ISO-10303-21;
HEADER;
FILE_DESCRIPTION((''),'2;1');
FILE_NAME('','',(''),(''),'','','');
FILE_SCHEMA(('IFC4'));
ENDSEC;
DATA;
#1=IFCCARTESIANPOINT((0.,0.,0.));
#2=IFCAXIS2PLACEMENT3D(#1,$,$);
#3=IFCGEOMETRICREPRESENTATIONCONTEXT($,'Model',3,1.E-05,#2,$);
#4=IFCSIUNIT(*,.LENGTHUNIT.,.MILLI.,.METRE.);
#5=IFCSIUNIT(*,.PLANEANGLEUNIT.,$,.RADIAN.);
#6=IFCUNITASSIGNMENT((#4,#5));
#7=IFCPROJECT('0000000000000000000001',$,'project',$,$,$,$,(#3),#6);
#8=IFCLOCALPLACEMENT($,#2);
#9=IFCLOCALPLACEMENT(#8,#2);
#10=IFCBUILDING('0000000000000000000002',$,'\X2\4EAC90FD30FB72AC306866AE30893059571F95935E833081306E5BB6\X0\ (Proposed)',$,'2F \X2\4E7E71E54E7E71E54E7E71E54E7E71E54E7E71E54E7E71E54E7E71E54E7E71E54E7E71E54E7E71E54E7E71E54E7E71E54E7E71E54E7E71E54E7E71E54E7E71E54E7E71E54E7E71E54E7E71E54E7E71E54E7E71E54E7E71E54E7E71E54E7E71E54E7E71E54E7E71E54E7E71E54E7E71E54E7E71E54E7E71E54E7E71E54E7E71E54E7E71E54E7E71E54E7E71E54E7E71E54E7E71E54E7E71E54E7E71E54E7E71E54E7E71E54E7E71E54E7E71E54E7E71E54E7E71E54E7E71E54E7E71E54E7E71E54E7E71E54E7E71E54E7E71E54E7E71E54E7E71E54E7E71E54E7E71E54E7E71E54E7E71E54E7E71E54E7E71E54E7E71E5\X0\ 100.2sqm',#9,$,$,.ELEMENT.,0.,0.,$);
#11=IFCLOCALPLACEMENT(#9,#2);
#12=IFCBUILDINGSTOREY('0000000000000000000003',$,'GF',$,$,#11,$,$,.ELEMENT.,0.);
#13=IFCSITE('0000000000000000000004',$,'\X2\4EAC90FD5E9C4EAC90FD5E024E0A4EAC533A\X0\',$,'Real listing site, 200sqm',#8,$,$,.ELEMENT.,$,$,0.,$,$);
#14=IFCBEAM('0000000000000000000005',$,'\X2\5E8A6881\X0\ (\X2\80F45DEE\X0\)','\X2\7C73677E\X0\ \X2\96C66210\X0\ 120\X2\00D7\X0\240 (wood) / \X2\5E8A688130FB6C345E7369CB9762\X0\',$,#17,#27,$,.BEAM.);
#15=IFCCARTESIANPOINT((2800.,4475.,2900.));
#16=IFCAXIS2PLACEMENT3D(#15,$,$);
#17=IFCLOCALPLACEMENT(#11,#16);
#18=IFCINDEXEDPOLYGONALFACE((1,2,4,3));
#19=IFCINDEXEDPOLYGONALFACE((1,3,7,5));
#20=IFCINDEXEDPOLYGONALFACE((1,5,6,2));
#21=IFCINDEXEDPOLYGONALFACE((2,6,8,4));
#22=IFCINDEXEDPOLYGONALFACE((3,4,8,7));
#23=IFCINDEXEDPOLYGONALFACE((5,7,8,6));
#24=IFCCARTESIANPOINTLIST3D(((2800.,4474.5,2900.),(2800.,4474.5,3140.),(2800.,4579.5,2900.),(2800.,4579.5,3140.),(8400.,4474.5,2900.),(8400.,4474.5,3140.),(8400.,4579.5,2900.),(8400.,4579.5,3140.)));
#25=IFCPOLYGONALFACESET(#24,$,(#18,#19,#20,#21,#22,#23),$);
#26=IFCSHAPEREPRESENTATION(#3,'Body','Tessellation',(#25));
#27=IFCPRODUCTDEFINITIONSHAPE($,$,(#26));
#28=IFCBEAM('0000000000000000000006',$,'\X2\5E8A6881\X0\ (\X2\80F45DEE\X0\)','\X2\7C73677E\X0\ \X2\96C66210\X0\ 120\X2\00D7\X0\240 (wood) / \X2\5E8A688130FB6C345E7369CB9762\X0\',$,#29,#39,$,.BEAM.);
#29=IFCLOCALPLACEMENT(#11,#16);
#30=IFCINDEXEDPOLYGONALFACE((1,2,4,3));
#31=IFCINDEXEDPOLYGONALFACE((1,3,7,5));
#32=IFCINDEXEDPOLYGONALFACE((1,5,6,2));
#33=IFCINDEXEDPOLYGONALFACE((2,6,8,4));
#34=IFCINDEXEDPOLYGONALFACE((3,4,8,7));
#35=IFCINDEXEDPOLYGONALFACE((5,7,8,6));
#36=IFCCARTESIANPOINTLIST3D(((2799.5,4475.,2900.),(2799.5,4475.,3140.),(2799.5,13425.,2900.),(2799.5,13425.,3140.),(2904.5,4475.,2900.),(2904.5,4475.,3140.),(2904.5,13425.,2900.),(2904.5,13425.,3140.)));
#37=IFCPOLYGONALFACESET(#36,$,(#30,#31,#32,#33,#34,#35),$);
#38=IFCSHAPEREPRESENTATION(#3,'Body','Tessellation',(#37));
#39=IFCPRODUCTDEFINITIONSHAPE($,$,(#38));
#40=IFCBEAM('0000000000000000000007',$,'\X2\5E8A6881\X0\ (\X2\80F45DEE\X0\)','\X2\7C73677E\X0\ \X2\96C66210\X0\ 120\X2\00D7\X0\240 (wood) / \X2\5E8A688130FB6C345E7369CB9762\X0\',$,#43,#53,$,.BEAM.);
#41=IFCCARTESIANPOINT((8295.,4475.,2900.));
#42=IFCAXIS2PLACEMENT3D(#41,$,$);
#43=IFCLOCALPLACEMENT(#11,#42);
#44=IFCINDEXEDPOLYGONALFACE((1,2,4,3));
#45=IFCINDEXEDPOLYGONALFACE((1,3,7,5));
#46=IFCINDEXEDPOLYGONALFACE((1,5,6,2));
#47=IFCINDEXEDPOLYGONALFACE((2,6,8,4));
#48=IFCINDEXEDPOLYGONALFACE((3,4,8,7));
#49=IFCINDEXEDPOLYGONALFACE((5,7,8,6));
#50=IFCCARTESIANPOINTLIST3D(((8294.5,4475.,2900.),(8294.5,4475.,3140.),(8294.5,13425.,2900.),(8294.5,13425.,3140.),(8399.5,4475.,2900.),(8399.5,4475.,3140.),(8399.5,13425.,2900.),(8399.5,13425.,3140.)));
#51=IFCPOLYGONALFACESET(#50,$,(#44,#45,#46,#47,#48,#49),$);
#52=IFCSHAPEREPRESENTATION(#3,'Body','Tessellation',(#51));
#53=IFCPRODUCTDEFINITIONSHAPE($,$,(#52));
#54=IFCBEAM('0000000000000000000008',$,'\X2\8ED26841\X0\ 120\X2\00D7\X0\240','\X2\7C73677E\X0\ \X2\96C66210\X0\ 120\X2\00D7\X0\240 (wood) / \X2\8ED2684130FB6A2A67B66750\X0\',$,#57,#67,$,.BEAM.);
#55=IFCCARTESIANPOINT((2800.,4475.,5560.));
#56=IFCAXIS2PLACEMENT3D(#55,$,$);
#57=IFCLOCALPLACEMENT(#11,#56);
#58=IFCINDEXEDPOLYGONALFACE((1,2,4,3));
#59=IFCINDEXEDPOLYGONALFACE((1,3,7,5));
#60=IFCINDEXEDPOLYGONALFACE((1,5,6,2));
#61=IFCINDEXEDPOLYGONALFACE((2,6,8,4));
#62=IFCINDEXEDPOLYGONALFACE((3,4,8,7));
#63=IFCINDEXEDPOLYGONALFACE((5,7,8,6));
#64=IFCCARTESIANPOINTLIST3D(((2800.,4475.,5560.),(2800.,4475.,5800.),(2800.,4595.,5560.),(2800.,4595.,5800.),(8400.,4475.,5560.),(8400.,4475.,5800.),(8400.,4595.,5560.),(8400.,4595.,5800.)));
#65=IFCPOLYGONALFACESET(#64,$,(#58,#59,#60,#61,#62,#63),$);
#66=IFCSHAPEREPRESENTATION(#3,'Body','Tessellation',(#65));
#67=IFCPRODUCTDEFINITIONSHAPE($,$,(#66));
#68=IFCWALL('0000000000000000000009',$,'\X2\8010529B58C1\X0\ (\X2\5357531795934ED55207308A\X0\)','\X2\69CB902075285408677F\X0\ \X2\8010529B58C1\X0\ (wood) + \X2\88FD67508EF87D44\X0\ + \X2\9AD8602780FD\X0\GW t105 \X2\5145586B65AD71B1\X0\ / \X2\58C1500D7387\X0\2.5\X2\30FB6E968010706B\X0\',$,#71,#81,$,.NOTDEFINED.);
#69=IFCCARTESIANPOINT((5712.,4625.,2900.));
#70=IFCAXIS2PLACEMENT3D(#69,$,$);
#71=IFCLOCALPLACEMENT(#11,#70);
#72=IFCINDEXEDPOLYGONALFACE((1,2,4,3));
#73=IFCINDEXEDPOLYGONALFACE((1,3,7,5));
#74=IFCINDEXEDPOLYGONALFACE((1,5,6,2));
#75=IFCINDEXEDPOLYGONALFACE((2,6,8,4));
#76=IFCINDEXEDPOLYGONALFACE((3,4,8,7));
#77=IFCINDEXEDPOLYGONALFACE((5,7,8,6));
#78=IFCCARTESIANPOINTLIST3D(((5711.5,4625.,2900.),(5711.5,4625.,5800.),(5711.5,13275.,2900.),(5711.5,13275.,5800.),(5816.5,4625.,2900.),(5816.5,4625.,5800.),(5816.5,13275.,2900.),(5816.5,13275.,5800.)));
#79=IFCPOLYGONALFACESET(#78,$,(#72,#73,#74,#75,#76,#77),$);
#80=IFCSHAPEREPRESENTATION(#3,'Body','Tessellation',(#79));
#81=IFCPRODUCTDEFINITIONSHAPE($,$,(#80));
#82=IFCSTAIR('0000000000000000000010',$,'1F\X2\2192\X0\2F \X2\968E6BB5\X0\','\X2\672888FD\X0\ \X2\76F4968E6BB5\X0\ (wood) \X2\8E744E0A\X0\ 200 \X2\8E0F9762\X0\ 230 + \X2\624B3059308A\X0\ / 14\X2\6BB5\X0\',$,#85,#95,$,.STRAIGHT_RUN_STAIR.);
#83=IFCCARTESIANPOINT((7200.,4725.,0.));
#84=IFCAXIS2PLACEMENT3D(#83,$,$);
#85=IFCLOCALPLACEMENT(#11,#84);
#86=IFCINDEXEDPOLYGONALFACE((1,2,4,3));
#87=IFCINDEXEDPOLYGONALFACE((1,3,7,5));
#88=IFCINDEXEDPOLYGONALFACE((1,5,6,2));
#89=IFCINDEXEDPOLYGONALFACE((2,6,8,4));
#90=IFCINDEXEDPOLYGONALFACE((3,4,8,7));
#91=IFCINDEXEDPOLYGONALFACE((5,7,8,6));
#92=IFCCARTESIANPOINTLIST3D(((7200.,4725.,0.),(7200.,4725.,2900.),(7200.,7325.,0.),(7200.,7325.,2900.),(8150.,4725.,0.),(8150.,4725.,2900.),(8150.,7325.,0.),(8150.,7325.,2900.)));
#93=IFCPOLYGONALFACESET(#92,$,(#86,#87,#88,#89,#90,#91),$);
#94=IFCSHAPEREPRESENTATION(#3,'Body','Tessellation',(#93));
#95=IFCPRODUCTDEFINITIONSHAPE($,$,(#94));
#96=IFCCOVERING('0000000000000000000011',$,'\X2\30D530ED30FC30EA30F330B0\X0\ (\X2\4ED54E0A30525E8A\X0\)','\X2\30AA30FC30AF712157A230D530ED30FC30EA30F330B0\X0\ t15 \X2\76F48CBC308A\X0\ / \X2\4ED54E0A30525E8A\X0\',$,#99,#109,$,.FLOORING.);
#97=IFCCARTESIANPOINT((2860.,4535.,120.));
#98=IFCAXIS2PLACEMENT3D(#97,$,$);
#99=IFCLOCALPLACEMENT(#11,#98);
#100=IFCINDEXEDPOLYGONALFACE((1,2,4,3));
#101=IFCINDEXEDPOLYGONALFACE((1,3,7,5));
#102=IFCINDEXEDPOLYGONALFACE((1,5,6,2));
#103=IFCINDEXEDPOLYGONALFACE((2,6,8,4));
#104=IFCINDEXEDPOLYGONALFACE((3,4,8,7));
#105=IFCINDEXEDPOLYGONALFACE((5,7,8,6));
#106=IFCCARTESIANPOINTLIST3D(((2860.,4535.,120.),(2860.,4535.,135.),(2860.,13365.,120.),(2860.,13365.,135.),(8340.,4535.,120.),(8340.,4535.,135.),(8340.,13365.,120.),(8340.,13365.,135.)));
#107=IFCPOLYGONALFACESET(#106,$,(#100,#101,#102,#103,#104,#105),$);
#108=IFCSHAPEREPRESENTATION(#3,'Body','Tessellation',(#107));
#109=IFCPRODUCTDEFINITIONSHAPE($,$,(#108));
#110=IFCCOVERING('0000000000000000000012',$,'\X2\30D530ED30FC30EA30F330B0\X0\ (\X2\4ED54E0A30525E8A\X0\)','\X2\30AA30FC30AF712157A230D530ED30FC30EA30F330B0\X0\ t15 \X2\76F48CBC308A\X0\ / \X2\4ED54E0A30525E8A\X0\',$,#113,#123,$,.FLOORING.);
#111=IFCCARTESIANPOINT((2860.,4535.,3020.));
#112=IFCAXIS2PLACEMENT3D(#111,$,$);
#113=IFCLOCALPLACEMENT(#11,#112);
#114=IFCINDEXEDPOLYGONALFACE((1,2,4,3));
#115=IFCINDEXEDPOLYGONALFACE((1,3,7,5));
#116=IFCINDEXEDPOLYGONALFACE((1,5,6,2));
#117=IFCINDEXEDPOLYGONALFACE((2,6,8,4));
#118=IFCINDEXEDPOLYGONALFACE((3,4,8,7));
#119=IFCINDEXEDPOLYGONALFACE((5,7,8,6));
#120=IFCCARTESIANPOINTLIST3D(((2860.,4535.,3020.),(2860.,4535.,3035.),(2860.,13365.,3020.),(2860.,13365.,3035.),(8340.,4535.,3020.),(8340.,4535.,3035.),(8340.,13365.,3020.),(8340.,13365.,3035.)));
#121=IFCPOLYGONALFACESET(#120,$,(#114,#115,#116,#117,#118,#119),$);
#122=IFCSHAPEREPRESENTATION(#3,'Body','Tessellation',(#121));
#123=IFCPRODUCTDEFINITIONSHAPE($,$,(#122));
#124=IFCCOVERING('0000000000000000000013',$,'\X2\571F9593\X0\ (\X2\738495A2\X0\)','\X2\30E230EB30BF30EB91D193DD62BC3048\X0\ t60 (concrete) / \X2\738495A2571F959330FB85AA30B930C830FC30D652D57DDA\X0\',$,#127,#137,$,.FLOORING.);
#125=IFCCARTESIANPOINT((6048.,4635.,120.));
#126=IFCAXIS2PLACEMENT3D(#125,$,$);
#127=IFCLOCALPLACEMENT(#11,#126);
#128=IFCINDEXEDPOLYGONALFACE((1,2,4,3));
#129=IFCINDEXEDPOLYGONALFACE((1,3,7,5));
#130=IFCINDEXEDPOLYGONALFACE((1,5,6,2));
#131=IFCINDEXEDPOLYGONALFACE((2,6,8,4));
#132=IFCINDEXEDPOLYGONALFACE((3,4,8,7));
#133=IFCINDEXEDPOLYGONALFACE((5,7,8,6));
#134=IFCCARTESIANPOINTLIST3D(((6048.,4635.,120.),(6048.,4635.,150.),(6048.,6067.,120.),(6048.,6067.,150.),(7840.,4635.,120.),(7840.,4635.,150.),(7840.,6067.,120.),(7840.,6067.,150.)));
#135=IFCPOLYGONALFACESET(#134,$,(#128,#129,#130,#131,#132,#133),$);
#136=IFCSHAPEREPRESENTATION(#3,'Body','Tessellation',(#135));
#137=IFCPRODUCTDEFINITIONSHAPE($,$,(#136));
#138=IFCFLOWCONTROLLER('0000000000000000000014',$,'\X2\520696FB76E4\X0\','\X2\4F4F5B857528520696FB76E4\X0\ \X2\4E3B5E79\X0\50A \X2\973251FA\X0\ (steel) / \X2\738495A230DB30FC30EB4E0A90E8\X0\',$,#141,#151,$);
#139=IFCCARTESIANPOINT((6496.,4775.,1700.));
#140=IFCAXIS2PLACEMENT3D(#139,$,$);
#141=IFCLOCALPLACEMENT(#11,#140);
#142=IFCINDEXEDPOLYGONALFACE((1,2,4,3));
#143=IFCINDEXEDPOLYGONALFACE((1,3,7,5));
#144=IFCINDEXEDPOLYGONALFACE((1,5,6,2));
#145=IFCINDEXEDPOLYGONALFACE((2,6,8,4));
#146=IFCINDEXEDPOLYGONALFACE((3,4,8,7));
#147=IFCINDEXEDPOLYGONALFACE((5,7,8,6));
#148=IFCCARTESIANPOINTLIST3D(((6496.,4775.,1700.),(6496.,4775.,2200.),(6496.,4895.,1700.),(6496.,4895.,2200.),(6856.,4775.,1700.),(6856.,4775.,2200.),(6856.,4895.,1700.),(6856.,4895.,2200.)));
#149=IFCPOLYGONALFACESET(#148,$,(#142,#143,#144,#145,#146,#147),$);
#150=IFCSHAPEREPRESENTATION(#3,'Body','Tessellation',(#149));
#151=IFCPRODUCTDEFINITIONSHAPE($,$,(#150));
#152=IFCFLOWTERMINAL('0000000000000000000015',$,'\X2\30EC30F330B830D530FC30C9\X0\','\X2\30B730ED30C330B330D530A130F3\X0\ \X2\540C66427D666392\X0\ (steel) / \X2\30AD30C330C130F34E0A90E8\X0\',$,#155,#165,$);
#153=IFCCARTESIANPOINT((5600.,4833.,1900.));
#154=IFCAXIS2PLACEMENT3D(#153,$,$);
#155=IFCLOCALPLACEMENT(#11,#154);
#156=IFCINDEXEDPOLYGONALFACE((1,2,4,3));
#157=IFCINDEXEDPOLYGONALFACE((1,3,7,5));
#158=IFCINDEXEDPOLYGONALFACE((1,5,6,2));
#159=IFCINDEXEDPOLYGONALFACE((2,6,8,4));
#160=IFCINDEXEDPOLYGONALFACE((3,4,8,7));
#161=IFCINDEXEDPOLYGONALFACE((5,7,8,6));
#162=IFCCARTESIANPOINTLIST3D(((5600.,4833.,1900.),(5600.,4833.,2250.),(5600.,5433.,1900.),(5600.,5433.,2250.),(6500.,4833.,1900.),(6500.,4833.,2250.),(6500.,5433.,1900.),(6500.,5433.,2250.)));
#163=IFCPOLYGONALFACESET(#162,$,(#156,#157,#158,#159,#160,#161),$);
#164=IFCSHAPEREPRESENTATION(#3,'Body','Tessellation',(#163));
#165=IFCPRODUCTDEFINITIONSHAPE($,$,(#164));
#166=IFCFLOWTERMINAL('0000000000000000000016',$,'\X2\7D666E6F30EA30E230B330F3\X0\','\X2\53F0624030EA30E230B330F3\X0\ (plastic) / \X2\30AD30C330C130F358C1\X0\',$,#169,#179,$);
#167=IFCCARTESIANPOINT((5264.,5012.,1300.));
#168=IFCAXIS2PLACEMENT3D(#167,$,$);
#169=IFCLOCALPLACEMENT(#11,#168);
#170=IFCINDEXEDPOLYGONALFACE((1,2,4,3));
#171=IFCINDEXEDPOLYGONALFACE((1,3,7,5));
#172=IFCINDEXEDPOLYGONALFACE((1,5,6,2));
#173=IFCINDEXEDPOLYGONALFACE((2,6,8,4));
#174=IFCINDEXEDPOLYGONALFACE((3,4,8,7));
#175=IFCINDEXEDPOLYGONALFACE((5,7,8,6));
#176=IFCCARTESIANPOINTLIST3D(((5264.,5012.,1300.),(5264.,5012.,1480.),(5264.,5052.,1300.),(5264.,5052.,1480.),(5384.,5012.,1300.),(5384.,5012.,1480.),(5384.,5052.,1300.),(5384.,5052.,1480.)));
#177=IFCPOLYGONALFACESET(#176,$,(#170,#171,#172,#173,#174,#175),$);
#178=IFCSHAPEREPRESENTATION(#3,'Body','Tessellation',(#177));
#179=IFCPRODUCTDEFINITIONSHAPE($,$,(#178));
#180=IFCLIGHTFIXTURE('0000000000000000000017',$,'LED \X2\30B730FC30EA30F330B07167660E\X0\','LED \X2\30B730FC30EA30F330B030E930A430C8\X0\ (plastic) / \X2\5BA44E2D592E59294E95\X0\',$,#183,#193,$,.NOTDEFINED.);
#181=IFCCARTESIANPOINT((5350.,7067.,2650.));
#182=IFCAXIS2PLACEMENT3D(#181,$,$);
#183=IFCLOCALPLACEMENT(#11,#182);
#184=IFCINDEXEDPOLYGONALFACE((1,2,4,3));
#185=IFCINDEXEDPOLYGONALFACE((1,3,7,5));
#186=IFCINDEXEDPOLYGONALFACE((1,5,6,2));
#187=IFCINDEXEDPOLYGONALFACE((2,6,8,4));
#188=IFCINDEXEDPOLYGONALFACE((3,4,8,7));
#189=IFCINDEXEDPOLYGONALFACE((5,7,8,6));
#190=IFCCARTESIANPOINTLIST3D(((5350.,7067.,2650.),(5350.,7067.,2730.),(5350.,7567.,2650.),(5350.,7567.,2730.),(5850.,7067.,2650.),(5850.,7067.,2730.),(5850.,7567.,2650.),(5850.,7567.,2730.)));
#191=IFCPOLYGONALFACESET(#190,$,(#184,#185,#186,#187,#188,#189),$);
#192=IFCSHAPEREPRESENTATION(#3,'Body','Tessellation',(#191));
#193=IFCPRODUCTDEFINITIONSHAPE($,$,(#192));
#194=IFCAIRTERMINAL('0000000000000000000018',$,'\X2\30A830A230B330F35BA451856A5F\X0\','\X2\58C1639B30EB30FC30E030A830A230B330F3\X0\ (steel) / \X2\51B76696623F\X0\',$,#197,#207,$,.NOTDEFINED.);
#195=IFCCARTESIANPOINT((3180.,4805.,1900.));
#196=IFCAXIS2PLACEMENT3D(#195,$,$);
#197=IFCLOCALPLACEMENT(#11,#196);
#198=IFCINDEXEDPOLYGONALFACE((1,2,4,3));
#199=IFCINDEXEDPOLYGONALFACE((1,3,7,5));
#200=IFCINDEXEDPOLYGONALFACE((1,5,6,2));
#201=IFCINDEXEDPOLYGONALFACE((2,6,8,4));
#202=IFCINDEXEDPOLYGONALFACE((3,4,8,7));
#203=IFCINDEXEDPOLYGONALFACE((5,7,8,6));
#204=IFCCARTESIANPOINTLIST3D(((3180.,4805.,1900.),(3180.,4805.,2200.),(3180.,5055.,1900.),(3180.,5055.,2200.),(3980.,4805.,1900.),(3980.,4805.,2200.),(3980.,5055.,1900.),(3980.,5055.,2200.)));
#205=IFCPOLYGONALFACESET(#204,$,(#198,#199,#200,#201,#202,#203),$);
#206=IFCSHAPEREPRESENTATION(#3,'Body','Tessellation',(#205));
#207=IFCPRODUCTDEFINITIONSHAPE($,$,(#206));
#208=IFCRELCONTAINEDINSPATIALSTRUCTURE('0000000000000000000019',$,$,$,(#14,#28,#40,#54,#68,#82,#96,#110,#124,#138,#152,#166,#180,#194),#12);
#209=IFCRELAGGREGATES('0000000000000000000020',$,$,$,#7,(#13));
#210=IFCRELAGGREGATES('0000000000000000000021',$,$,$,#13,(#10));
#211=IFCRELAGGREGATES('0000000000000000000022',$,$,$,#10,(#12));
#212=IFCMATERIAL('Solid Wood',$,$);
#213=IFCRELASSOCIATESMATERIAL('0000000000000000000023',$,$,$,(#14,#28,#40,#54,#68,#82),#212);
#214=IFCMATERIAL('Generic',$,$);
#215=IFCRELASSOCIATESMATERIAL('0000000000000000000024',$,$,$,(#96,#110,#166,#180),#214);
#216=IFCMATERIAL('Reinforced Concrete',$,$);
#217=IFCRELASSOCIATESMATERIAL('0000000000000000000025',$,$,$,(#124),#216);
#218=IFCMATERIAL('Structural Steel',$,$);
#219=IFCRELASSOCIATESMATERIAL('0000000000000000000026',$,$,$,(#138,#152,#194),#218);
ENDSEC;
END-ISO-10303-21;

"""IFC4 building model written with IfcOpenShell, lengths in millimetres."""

from ifc_helpers import new_model, si_unit, frame, frame_2d, origin, place, context, project, spatial, rectangle, extrude, material, element, save


model = new_model("IFC4")

# Units and contexts
model_context = context("Model", 3, precision=1e-05, world=origin())
ifc_project = project(units=[si_unit("LENGTHUNIT", "METRE", prefix="MILLI"), si_unit("PLANEANGLEUNIT", "RADIAN")], contexts=[model_context])

# Site, building, storey
site_placement = place(None, origin())
site = spatial("IfcSite", under=ifc_project, at=site_placement, Name="京都府京都市上京区", ObjectType="Real listing site, 200sqm", CompositionType="ELEMENT", RefElevation=0.0)
building_placement = place(site_placement, origin())
building = spatial("IfcBuilding", under=site, at=building_placement, Name="京都・犬と暮らす土間広めの家 (Proposed)", ObjectType="2F 乾燥乾燥乾燥乾燥乾燥乾燥乾燥乾燥乾燥乾燥乾燥乾燥乾燥乾燥乾燥乾燥乾燥乾燥乾燥乾燥乾燥乾燥乾燥乾燥乾燥乾燥乾燥乾燥乾燥乾燥乾燥乾燥乾燥乾燥乾燥乾燥乾燥乾燥乾燥乾燥乾燥乾燥乾燥乾燥乾燥乾燥乾燥乾燥乾燥乾燥乾燥乾燥乾燥乾燥乾燥乾燥乾燥乾燥乾燥乾燥 100.2sqm", CompositionType="ELEMENT", ElevationOfRefHeight=0.0, ElevationOfTerrain=0.0)
storey_placement = place(building_placement, origin())
storey = spatial("IfcBuildingStorey", under=building, at=storey_placement, Name="GF", CompositionType="ELEMENT", Elevation=0.0)

# Beams
ifc_material_1 = material(Name="Solid Wood")
beam_1_placement = place(storey_placement, frame((2800.0, 4475.0, 2900.0)))
element("IfcBeam", 1, at=beam_1_placement, inside=storey, material=ifc_material_1, Name="床梁 (胴差)", Description="米松 集成 120×240 (wood) / 床梁・水平構面", PredefinedType="BEAM", context=model_context, shape_type="SweptSolid", body=[
    extrude(rectangle(XDim=5600.0, YDim=105.0, at=frame_2d((2800.0, 52.0))), frame((2800.0, 4475.0, 2900.0)), (0.0, 0.0, 1.0), 240.0),
])
beam_2_placement = place(storey_placement, frame((2800.0, 4475.0, 2900.0)))
element("IfcBeam", 2, at=beam_2_placement, inside=storey, material=ifc_material_1, Name="床梁 (胴差)", Description="米松 集成 120×240 (wood) / 床梁・水平構面", PredefinedType="BEAM", context=model_context, shape_type="SweptSolid", body=[
    extrude(rectangle(XDim=105.0, YDim=8950.0, at=frame_2d((52.0, 4475.0))), frame((2800.0, 4475.0, 2900.0)), (0.0, 0.0, 1.0), 240.0),
])
beam_3_placement = place(storey_placement, frame((8295.0, 4475.0, 2900.0)))
element("IfcBeam", 3, at=beam_3_placement, inside=storey, material=ifc_material_1, Name="床梁 (胴差)", Description="米松 集成 120×240 (wood) / 床梁・水平構面", PredefinedType="BEAM", context=model_context, shape_type="SweptSolid", body=[
    extrude(rectangle(XDim=105.0, YDim=8950.0, at=frame_2d((52.0, 4475.0))), frame((8295.0, 4475.0, 2900.0)), (0.0, 0.0, 1.0), 240.0),
])
beam_4_placement = place(storey_placement, frame((2800.0, 4475.0, 5560.0)))
element("IfcBeam", 4, at=beam_4_placement, inside=storey, material=ifc_material_1, Name="軒桁 120×240", Description="米松 集成 120×240 (wood) / 軒桁・横架材", PredefinedType="BEAM", context=model_context, shape_type="SweptSolid", body=[
    extrude(rectangle(XDim=5600.0, YDim=120.0, at=frame_2d((2800.0, 60.0))), frame((2800.0, 4475.0, 5560.0)), (0.0, 0.0, 1.0), 240.0),
])

# Wall
wall_1_placement = place(storey_placement, frame((5712.0, 4625.0, 2900.0)))
element("IfcWall", 5, at=wall_1_placement, inside=storey, material=ifc_material_1, Name="耐力壁 (南北間仕切り)", Description="構造用合板 耐力壁 (wood) + 製材軸組 + 高性能GW t105 充填断熱 / 壁倍率2.5・準耐火", PredefinedType="NOTDEFINED", context=model_context, shape_type="SweptSolid", body=[
    extrude(rectangle(XDim=105.0, YDim=8650.0, at=frame_2d((52.0, 4325.0))), frame((5712.0, 4625.0, 2900.0)), (0.0, 0.0, 1.0), 2900.0),
])

# Stair
stair_placement = place(storey_placement, frame((7200.0, 4725.0, 0.0)))
element("IfcStair", 6, at=stair_placement, inside=storey, material=ifc_material_1, Name="1F→2F 階段", Description="木製 直階段 (wood) 蹴上 200 踏面 230 + 手すり / 14段", PredefinedType="STRAIGHT_RUN_STAIR", context=model_context, shape_type="SweptSolid", body=[
    extrude(rectangle(XDim=950.0, YDim=2600.0, at=frame_2d((475.0, 1300.0))), frame((7200.0, 4725.0, 0.0)), (0.0, 0.0, 1.0), 2900.0),
])

# Coverings
ifc_material_2 = material(Name="Generic")
covering_1_placement = place(storey_placement, frame((2860.0, 4535.0, 120.0)))
element("IfcCovering", 7, at=covering_1_placement, inside=storey, material=ifc_material_2, Name="フローリング (仕上げ床)", Description="オーク無垢フローリング t15 直貼り / 仕上げ床", PredefinedType="FLOORING", context=model_context, shape_type="SweptSolid", body=[
    extrude(rectangle(XDim=5480.0, YDim=8830.0, at=frame_2d((2740.0, 4415.0))), frame((2860.0, 4535.0, 120.0)), (0.0, 0.0, 1.0), 15.0),
])
covering_2_placement = place(storey_placement, frame((2860.0, 4535.0, 3020.0)))
element("IfcCovering", 8, at=covering_2_placement, inside=storey, material=ifc_material_2, Name="フローリング (仕上げ床)", Description="オーク無垢フローリング t15 直貼り / 仕上げ床", PredefinedType="FLOORING", context=model_context, shape_type="SweptSolid", body=[
    extrude(rectangle(XDim=5480.0, YDim=8830.0, at=frame_2d((2740.0, 4415.0))), frame((2860.0, 4535.0, 3020.0)), (0.0, 0.0, 1.0), 15.0),
])
ifc_material_3 = material(Name="Reinforced Concrete")
covering_3_placement = place(storey_placement, frame((6048.0, 4635.0, 120.0)))
element("IfcCovering", 9, at=covering_3_placement, inside=storey, material=ifc_material_3, Name="土間 (玄関)", Description="モルタル金鏝押え t60 (concrete) / 玄関土間・薪ストーブ動線", PredefinedType="FLOORING", context=model_context, shape_type="SweptSolid", body=[
    extrude(rectangle(XDim=1792.0, YDim=1432.0, at=frame_2d((896.0, 716.0))), frame((6048.0, 4635.0, 120.0)), (0.0, 0.0, 1.0), 30.0),
])

# Flow controller
ifc_material_4 = material(Name="Structural Steel")
flow_controller_placement = place(storey_placement, frame((6496.0, 4775.0, 1700.0)))
element("IfcFlowController", 10, at=flow_controller_placement, inside=storey, material=ifc_material_4, Name="分電盤", Description="住宅用分電盤 主幹50A 露出 (steel) / 玄関ホール上部", context=model_context, shape_type="SweptSolid", body=[
    extrude(rectangle(XDim=360.0, YDim=120.0, at=frame_2d((180.0, 60.0))), frame((6496.0, 4775.0, 1700.0)), (0.0, 0.0, 1.0), 500.0),
])

# Flow terminals
flow_terminal_1_placement = place(storey_placement, frame((5600.0, 4833.0, 1900.0)))
element("IfcFlowTerminal", 11, at=flow_terminal_1_placement, inside=storey, material=ifc_material_4, Name="レンジフード", Description="シロッコファン 同時給排 (steel) / キッチン上部", context=model_context, shape_type="SweptSolid", body=[
    extrude(rectangle(XDim=900.0, YDim=600.0, at=frame_2d((450.0, 300.0))), frame((5600.0, 4833.0, 1900.0)), (0.0, 0.0, 1.0), 350.0),
])
flow_terminal_2_placement = place(storey_placement, frame((5264.0, 5012.0, 1300.0)))
element("IfcFlowTerminal", 12, at=flow_terminal_2_placement, inside=storey, material=ifc_material_2, Name="給湯リモコン", Description="台所リモコン (plastic) / キッチン壁", context=model_context, shape_type="SweptSolid", body=[
    extrude(rectangle(XDim=120.0, YDim=40.0, at=frame_2d((60.0, 20.0))), frame((5264.0, 5012.0, 1300.0)), (0.0, 0.0, 1.0), 180.0),
])

# Light fixture
light_fixture_1_placement = place(storey_placement, frame((5350.0, 7067.0, 2650.0)))
element("IfcLightFixture", 13, at=light_fixture_1_placement, inside=storey, material=ifc_material_2, Name="LED シーリング照明", Description="LED シーリングライト (plastic) / 室中央天井", PredefinedType="NOTDEFINED", context=model_context, shape_type="SweptSolid", body=[
    extrude(rectangle(XDim=500.0, YDim=500.0, at=frame_2d((250.0, 250.0))), frame((5350.0, 7067.0, 2650.0)), (0.0, 0.0, 1.0), 80.0),
])

# Air terminal
air_terminal_1_placement = place(storey_placement, frame((3180.0, 4805.0, 1900.0)))
element("IfcAirTerminal", 14, at=air_terminal_1_placement, inside=storey, material=ifc_material_4, Name="エアコン室内機", Description="壁掛ルームエアコン (steel) / 冷暖房", PredefinedType="NOTDEFINED", context=model_context, shape_type="SweptSolid", body=[
    extrude(rectangle(XDim=800.0, YDim=250.0, at=frame_2d((400.0, 125.0))), frame((3180.0, 4805.0, 1900.0)), (0.0, 0.0, 1.0), 300.0),
])

save(model, "model.ifc")
